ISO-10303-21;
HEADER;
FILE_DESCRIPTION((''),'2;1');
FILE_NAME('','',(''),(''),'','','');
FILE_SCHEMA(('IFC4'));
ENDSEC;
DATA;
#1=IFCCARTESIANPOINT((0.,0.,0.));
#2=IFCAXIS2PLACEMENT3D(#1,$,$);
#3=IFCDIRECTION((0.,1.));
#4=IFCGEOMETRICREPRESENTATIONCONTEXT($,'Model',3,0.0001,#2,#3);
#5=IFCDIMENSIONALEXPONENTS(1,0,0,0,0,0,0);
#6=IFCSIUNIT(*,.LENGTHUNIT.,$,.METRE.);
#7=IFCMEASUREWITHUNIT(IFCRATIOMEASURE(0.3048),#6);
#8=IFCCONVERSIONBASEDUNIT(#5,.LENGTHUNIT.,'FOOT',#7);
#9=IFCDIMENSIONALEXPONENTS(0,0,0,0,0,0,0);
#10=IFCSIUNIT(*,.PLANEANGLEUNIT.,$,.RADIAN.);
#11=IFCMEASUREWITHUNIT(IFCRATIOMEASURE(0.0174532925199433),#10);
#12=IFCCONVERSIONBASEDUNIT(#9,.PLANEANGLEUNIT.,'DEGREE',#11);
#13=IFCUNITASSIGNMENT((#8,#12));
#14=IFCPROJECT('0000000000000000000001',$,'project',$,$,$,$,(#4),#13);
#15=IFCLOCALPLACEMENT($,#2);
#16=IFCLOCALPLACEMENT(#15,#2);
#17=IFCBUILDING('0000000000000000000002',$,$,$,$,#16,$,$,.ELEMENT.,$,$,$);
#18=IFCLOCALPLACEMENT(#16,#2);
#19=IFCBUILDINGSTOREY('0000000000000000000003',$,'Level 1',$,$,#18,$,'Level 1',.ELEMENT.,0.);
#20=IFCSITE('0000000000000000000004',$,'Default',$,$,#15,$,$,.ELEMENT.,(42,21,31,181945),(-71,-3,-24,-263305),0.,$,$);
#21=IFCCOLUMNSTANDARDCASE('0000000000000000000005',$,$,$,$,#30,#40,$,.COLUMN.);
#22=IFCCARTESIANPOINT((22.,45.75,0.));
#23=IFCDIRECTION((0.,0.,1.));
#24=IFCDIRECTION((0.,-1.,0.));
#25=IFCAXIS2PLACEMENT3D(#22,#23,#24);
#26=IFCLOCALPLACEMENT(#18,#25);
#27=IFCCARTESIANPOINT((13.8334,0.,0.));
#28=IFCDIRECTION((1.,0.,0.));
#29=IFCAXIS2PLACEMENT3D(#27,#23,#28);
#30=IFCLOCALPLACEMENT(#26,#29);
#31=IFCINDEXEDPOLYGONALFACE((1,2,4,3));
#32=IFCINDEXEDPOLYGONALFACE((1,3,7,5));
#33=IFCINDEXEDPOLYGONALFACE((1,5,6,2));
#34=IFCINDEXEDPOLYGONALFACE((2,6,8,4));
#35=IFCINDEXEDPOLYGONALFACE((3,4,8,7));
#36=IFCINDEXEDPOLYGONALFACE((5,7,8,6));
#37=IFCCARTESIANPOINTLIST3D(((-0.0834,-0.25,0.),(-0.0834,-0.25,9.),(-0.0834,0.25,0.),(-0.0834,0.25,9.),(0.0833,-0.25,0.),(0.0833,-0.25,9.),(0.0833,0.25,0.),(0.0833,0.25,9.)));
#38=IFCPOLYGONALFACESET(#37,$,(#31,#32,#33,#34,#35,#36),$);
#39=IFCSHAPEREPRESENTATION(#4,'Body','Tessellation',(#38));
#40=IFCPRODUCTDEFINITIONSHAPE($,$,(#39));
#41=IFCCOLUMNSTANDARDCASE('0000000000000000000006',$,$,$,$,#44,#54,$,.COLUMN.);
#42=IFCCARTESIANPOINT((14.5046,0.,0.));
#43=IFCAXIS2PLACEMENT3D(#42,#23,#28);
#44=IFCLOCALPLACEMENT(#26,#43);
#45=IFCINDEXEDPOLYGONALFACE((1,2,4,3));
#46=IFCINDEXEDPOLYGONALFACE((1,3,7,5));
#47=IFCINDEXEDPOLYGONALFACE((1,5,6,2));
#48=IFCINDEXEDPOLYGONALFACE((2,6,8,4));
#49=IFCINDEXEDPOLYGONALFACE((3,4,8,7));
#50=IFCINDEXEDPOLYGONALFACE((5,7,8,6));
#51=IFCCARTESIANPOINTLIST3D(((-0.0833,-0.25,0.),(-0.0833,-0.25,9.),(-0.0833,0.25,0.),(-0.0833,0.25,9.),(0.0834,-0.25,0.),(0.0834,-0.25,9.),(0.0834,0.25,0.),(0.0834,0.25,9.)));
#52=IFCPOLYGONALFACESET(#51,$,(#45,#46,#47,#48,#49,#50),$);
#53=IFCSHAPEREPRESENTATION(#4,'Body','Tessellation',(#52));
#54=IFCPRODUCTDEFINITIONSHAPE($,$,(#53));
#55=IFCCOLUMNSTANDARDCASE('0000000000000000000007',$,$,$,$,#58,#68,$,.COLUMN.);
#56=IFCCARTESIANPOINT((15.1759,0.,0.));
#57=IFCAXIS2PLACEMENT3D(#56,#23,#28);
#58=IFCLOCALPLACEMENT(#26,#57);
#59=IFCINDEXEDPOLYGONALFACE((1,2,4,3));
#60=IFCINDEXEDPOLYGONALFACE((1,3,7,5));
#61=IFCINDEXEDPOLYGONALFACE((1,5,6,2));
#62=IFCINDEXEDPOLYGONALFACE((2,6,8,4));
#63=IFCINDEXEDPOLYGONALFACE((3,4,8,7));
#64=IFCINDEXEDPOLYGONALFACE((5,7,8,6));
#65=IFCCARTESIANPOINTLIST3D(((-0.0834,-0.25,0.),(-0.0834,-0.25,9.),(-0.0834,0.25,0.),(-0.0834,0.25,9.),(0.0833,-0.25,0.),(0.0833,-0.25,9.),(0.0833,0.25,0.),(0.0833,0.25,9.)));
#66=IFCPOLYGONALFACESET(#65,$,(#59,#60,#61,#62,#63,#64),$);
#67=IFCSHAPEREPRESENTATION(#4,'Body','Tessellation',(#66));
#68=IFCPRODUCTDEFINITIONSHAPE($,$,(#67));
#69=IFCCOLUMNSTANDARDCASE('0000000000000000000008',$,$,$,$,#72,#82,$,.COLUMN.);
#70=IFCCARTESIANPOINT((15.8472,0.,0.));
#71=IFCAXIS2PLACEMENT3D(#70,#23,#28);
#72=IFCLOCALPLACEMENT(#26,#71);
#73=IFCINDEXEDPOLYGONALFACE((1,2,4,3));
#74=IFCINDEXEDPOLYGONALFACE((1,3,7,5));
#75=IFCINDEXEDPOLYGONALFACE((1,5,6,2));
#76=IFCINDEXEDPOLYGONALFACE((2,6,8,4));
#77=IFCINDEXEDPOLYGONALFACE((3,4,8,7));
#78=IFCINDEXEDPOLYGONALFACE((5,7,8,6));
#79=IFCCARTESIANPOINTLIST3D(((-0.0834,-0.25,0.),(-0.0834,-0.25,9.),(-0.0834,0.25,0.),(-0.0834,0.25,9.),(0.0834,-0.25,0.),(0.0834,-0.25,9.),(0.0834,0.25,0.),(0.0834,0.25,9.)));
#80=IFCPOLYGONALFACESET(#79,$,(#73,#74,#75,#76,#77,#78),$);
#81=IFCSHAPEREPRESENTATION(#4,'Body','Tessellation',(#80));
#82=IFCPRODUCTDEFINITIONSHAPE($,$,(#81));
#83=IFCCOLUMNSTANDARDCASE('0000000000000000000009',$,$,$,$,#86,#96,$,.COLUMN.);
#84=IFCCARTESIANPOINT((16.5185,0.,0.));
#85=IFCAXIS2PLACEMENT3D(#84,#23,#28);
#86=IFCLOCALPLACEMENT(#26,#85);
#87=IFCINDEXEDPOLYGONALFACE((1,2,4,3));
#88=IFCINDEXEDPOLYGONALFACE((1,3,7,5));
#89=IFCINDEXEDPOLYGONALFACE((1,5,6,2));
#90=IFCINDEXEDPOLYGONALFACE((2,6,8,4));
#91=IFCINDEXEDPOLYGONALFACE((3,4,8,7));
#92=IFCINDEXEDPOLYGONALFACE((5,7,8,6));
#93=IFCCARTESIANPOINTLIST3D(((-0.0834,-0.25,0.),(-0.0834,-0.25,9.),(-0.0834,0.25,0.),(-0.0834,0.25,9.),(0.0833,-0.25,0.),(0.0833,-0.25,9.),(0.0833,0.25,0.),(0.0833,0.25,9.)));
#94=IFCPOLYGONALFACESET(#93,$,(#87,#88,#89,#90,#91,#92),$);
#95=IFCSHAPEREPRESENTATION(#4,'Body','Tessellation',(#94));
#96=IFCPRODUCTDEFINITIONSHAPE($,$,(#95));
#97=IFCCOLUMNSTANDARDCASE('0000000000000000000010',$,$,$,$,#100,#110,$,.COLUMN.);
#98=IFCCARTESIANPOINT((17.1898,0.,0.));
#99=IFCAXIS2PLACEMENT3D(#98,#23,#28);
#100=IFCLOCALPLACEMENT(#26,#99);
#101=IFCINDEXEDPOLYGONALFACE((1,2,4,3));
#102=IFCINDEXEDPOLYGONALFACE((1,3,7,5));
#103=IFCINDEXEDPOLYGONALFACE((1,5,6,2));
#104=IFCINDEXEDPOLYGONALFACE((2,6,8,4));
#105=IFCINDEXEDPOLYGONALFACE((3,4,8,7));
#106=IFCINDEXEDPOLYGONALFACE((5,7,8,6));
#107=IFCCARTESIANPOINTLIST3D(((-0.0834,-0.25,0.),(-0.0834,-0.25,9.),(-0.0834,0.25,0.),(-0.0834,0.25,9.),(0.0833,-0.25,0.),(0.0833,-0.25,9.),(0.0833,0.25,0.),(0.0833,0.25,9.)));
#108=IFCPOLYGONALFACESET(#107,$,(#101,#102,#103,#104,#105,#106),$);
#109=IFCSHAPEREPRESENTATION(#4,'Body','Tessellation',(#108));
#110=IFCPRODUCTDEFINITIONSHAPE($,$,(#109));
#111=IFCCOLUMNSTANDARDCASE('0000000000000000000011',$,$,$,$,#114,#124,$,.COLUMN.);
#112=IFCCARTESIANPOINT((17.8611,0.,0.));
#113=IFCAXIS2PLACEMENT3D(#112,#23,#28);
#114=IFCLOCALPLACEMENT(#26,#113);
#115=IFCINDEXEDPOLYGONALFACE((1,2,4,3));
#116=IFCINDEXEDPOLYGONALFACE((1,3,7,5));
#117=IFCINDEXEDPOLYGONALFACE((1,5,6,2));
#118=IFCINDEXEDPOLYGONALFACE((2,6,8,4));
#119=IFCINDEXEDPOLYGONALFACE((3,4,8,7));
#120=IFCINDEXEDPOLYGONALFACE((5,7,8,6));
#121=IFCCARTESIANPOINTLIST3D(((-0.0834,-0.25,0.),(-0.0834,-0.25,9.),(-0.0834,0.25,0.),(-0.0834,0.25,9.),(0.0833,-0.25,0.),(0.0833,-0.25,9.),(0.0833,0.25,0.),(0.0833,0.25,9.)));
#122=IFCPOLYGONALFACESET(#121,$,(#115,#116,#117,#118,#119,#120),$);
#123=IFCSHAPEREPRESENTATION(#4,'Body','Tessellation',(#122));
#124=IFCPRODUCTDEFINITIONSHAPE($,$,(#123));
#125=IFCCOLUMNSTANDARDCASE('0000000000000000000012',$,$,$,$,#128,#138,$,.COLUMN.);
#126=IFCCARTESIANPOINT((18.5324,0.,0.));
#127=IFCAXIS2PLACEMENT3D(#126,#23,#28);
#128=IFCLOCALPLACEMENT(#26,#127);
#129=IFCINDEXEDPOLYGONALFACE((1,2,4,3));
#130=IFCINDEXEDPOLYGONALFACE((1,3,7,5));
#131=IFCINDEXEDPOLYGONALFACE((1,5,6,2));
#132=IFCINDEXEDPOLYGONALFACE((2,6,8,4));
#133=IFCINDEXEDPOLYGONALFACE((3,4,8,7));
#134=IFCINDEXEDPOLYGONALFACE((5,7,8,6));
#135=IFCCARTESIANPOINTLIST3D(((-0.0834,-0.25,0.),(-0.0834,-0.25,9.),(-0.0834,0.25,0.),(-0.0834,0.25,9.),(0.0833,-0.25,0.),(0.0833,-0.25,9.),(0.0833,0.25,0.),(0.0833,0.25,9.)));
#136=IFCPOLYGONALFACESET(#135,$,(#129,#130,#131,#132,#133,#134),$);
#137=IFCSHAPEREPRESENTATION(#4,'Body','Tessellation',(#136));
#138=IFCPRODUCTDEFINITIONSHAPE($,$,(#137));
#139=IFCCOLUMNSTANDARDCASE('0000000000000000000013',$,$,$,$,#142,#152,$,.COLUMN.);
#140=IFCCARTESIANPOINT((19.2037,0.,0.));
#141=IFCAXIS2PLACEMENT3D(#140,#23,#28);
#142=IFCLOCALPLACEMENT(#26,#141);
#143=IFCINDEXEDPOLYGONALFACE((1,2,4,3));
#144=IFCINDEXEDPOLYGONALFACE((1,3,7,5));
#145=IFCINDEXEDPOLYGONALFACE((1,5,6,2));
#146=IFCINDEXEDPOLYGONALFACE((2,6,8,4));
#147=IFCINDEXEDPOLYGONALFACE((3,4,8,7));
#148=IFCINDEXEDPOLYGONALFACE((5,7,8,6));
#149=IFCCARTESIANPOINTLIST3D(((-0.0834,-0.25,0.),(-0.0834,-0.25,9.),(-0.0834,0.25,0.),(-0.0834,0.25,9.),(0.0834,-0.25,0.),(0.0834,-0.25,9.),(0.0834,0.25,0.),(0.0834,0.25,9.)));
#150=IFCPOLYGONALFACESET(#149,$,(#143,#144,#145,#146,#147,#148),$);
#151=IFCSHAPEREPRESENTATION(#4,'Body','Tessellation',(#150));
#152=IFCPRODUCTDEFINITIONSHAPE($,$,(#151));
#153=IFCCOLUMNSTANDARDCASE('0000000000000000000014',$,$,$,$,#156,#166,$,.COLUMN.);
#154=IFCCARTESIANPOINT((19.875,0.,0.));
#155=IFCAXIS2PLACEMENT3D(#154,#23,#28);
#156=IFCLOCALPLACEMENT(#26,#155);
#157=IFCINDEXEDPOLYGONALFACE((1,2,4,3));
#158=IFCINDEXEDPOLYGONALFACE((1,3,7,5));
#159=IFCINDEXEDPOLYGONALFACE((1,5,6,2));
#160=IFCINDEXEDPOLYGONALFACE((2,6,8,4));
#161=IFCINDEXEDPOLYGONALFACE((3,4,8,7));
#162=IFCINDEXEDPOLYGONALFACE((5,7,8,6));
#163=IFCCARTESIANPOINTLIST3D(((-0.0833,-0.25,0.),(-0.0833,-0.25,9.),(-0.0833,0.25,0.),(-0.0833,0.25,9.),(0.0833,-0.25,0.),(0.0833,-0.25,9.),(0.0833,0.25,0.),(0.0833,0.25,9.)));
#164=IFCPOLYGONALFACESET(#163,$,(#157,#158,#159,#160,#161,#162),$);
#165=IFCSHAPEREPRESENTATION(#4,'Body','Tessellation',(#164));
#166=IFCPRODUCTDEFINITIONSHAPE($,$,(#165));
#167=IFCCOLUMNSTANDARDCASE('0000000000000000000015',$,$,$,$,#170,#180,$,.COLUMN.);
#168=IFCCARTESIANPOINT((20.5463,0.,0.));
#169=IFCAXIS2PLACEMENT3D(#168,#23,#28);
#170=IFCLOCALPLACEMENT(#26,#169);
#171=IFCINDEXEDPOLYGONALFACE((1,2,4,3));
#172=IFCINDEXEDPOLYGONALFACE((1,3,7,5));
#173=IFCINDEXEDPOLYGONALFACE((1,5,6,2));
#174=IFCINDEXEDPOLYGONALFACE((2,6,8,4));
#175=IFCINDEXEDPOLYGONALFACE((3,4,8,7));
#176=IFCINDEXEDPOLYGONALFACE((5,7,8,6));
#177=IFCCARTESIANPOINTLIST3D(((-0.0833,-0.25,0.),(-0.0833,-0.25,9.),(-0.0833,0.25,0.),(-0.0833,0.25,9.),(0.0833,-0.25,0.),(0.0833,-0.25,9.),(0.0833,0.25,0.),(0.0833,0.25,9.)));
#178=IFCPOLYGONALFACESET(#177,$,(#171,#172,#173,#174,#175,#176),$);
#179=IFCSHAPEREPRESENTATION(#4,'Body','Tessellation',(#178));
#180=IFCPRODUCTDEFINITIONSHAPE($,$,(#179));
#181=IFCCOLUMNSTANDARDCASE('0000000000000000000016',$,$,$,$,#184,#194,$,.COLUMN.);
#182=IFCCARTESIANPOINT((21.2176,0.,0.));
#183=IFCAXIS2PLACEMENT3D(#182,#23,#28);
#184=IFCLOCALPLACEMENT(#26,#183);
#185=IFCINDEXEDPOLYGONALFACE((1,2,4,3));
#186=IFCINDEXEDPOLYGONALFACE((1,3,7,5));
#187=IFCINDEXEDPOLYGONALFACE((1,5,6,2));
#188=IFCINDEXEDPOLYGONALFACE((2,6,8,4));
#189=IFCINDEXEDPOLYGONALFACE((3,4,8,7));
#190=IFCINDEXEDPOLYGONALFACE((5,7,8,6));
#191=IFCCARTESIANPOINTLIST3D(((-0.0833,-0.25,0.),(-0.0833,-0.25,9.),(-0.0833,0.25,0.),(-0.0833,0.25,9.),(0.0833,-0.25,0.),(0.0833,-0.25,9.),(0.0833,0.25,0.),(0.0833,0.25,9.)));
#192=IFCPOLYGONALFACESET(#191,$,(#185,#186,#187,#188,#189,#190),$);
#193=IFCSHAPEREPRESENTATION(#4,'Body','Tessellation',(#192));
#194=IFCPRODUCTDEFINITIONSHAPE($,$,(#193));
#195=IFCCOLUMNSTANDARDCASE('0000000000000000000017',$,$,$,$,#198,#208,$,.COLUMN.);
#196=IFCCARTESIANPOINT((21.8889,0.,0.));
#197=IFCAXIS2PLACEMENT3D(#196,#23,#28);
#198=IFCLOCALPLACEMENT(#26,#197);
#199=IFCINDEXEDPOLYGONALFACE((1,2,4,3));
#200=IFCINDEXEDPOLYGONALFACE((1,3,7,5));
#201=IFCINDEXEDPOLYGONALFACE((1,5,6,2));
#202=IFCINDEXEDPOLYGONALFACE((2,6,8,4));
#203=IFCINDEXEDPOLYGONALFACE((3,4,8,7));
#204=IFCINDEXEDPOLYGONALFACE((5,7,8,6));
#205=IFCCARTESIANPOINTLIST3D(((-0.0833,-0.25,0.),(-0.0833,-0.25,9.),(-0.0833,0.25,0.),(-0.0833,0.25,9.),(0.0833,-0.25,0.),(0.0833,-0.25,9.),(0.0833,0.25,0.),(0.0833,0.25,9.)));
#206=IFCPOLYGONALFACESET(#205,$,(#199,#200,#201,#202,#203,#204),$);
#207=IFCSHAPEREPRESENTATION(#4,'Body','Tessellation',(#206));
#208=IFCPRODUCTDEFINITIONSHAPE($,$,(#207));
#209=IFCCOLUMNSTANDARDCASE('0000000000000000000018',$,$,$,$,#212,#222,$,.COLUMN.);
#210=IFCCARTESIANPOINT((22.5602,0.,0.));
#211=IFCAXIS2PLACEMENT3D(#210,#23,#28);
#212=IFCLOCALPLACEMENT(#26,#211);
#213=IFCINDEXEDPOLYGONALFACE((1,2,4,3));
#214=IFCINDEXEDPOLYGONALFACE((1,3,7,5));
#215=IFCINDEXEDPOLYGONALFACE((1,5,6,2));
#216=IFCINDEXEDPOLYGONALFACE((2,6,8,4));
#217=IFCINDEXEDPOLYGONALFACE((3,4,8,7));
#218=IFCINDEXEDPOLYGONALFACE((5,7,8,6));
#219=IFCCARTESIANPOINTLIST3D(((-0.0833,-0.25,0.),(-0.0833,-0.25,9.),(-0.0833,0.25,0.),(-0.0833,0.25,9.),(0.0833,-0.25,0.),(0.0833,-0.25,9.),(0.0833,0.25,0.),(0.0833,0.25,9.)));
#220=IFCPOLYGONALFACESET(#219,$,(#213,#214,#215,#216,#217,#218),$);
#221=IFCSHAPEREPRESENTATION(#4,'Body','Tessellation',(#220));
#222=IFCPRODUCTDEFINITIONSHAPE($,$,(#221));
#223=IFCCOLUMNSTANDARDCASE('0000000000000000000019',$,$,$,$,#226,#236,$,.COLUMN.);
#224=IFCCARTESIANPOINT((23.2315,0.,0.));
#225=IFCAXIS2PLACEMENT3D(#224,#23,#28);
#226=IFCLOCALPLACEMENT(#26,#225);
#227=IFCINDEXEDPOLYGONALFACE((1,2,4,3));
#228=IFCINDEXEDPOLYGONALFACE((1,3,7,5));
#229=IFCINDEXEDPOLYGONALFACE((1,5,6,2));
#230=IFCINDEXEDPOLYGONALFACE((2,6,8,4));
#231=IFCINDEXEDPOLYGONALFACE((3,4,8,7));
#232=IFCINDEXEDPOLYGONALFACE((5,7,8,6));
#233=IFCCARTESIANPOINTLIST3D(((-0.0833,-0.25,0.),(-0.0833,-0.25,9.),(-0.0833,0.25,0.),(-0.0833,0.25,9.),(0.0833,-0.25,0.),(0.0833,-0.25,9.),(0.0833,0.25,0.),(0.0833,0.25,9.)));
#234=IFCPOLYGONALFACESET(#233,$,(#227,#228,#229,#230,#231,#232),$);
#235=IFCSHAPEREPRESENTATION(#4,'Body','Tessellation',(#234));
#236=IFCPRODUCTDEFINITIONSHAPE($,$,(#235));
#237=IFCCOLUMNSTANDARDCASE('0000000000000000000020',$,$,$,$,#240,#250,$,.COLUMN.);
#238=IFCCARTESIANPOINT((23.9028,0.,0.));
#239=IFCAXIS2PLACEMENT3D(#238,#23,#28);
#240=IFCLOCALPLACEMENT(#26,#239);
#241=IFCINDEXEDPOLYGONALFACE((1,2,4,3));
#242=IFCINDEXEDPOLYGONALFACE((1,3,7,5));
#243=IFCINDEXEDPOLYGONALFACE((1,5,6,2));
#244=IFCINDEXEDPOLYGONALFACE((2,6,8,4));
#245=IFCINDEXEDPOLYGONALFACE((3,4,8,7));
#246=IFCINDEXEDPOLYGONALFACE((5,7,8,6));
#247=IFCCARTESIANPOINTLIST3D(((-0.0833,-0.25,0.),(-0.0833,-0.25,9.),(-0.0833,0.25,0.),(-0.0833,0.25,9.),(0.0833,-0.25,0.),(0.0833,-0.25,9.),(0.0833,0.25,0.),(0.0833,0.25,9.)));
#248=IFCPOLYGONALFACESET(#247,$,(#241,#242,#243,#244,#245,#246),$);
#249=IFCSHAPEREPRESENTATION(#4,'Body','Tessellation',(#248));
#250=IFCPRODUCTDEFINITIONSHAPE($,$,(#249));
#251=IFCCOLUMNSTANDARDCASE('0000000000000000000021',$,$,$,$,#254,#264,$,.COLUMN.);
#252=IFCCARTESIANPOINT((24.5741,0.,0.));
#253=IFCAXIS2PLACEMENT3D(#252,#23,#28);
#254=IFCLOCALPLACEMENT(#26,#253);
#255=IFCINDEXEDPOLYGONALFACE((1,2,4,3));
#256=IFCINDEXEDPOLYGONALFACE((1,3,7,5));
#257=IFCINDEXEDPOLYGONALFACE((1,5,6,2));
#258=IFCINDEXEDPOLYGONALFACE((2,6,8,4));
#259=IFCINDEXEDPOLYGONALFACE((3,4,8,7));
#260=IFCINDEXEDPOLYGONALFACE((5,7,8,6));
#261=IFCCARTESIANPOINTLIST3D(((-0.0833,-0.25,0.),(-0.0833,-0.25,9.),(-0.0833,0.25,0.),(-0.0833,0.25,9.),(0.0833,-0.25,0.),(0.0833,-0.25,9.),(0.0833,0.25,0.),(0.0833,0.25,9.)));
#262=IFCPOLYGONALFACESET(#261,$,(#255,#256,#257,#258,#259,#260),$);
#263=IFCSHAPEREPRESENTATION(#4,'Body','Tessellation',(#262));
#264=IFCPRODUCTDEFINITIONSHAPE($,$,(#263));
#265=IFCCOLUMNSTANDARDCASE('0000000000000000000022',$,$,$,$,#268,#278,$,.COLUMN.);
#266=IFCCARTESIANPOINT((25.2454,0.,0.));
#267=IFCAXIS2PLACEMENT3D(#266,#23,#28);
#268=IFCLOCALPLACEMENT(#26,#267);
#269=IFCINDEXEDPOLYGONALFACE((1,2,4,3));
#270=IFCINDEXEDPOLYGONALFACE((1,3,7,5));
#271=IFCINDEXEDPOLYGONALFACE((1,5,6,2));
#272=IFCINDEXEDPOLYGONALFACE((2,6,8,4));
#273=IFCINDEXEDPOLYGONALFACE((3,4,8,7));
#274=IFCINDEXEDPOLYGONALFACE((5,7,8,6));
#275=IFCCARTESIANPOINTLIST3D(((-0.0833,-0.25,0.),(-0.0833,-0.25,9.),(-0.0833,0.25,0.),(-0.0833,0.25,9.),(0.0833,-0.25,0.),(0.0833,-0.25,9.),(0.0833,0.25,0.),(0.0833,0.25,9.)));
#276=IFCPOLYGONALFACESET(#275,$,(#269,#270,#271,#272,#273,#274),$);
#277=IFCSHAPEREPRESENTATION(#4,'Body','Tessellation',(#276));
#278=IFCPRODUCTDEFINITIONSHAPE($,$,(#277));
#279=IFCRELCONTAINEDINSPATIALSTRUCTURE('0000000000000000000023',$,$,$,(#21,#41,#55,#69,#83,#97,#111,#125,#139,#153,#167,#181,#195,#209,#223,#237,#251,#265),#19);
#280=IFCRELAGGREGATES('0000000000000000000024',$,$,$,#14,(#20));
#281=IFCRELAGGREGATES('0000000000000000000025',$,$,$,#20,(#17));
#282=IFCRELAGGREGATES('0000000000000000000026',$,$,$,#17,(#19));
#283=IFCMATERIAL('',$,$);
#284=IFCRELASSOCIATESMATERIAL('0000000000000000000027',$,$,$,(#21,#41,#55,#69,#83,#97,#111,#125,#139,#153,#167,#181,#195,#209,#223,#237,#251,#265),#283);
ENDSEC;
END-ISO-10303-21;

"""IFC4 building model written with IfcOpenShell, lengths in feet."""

from ifc_helpers import new_model, entity, si_unit, converted_unit, direction, frame, origin, place, context, project, spatial, rectangle, extrude, material, element, save


model = new_model("IFC4")

# Units and contexts
model_context = context("Model", 3, precision=0.0001, world=origin(), true_north=direction((0.0, 1.0)))
ifc_project = project(units=[converted_unit("LENGTHUNIT", "FOOT", entity("IfcRatioMeasure", 0.3048), si_unit("LENGTHUNIT", "METRE"), dimensions=[1, 0, 0, 0, 0, 0, 0]), converted_unit("PLANEANGLEUNIT", "DEGREE", entity("IfcRatioMeasure", 0.0174532925199433), si_unit("PLANEANGLEUNIT", "RADIAN"), dimensions=[0, 0, 0, 0, 0, 0, 0])], contexts=[model_context])

# Site, building, storey
site_placement = place(None, origin())
site = spatial("IfcSite", under=ifc_project, at=site_placement, Name="Default", CompositionType="ELEMENT", RefLatitude=(42, 21, 31, 181945), RefLongitude=(-71, -3, -24, -263305), RefElevation=0.0)
building_placement = place(site_placement, origin())
building = spatial("IfcBuilding", under=site, at=building_placement, CompositionType="ELEMENT")
storey_placement = place(building_placement, origin())
storey = spatial("IfcBuildingStorey", under=building, at=storey_placement, Name="Level 1", LongName="Level 1", CompositionType="ELEMENT", Elevation=0.0)

# Columns
ifc_material_1 = material(Name="")
placement_1 = place(storey_placement, frame((22.0, 45.75, 0.0), z_axis=(0.0, 0.0, 1.0), x_axis=(0.0, -1.0, 0.0)))
for number, where, z_axis, x_axis in (
    (1, (13.8334, 0.0, 0.0), (0.0, 0.0, 1.0), (1.0, 0.0, 0.0)),
    (2, (14.5046, 0.0, 0.0), (0.0, 0.0, 1.0), (1.0, 0.0, 0.0)),
    (3, (15.1759, 0.0, 0.0), (0.0, 0.0, 1.0), (1.0, 0.0, 0.0)),
    (4, (15.8472, 0.0, 0.0), (0.0, 0.0, 1.0), (1.0, 0.0, 0.0)),
    (5, (16.5185, 0.0, 0.0), (0.0, 0.0, 1.0), (1.0, 0.0, 0.0)),
    (6, (17.1898, 0.0, 0.0), (0.0, 0.0, 1.0), (1.0, 0.0, 0.0)),
    (7, (17.8611, 0.0, 0.0), (0.0, 0.0, 1.0), (1.0, 0.0, 0.0)),
    (8, (18.5324, 0.0, 0.0), (0.0, 0.0, 1.0), (1.0, 0.0, 0.0)),
    (9, (19.2037, 0.0, 0.0), (0.0, 0.0, 1.0), (1.0, 0.0, 0.0)),
    (10, (19.875, 0.0, 0.0), (0.0, 0.0, 1.0), (1.0, 0.0, 0.0)),
    (11, (20.5463, 0.0, 0.0), (0.0, 0.0, 1.0), (1.0, 0.0, 0.0)),
    (12, (21.2176, 0.0, 0.0), (0.0, 0.0, 1.0), (1.0, 0.0, 0.0)),
    (13, (21.8889, 0.0, 0.0), (0.0, 0.0, 1.0), (1.0, 0.0, 0.0)),
    (14, (22.5602, 0.0, 0.0), (0.0, 0.0, 1.0), (1.0, 0.0, 0.0)),
    (15, (23.2315, 0.0, 0.0), (0.0, 0.0, 1.0), (1.0, 0.0, 0.0)),
    (16, (23.9028, 0.0, 0.0), (0.0, 0.0, 1.0), (1.0, 0.0, 0.0)),
    (17, (24.5741, 0.0, 0.0), (0.0, 0.0, 1.0), (1.0, 0.0, 0.0)),
    (18, (25.2454, 0.0, 0.0), (0.0, 0.0, 1.0), (1.0, 0.0, 0.0)),
):
    element("IfcColumnStandardCase", number, at=place(placement_1, frame(where, z_axis=z_axis, x_axis=x_axis)), inside=storey, material=ifc_material_1, PredefinedType="COLUMN", context=model_context, shape_type="SweptSolid", body=[
        extrude(rectangle(XDim=0.1667, YDim=0.5), origin(), (0.0, 0.0, 1.0), 9.0),
    ])

save(model, "model.ifc")
